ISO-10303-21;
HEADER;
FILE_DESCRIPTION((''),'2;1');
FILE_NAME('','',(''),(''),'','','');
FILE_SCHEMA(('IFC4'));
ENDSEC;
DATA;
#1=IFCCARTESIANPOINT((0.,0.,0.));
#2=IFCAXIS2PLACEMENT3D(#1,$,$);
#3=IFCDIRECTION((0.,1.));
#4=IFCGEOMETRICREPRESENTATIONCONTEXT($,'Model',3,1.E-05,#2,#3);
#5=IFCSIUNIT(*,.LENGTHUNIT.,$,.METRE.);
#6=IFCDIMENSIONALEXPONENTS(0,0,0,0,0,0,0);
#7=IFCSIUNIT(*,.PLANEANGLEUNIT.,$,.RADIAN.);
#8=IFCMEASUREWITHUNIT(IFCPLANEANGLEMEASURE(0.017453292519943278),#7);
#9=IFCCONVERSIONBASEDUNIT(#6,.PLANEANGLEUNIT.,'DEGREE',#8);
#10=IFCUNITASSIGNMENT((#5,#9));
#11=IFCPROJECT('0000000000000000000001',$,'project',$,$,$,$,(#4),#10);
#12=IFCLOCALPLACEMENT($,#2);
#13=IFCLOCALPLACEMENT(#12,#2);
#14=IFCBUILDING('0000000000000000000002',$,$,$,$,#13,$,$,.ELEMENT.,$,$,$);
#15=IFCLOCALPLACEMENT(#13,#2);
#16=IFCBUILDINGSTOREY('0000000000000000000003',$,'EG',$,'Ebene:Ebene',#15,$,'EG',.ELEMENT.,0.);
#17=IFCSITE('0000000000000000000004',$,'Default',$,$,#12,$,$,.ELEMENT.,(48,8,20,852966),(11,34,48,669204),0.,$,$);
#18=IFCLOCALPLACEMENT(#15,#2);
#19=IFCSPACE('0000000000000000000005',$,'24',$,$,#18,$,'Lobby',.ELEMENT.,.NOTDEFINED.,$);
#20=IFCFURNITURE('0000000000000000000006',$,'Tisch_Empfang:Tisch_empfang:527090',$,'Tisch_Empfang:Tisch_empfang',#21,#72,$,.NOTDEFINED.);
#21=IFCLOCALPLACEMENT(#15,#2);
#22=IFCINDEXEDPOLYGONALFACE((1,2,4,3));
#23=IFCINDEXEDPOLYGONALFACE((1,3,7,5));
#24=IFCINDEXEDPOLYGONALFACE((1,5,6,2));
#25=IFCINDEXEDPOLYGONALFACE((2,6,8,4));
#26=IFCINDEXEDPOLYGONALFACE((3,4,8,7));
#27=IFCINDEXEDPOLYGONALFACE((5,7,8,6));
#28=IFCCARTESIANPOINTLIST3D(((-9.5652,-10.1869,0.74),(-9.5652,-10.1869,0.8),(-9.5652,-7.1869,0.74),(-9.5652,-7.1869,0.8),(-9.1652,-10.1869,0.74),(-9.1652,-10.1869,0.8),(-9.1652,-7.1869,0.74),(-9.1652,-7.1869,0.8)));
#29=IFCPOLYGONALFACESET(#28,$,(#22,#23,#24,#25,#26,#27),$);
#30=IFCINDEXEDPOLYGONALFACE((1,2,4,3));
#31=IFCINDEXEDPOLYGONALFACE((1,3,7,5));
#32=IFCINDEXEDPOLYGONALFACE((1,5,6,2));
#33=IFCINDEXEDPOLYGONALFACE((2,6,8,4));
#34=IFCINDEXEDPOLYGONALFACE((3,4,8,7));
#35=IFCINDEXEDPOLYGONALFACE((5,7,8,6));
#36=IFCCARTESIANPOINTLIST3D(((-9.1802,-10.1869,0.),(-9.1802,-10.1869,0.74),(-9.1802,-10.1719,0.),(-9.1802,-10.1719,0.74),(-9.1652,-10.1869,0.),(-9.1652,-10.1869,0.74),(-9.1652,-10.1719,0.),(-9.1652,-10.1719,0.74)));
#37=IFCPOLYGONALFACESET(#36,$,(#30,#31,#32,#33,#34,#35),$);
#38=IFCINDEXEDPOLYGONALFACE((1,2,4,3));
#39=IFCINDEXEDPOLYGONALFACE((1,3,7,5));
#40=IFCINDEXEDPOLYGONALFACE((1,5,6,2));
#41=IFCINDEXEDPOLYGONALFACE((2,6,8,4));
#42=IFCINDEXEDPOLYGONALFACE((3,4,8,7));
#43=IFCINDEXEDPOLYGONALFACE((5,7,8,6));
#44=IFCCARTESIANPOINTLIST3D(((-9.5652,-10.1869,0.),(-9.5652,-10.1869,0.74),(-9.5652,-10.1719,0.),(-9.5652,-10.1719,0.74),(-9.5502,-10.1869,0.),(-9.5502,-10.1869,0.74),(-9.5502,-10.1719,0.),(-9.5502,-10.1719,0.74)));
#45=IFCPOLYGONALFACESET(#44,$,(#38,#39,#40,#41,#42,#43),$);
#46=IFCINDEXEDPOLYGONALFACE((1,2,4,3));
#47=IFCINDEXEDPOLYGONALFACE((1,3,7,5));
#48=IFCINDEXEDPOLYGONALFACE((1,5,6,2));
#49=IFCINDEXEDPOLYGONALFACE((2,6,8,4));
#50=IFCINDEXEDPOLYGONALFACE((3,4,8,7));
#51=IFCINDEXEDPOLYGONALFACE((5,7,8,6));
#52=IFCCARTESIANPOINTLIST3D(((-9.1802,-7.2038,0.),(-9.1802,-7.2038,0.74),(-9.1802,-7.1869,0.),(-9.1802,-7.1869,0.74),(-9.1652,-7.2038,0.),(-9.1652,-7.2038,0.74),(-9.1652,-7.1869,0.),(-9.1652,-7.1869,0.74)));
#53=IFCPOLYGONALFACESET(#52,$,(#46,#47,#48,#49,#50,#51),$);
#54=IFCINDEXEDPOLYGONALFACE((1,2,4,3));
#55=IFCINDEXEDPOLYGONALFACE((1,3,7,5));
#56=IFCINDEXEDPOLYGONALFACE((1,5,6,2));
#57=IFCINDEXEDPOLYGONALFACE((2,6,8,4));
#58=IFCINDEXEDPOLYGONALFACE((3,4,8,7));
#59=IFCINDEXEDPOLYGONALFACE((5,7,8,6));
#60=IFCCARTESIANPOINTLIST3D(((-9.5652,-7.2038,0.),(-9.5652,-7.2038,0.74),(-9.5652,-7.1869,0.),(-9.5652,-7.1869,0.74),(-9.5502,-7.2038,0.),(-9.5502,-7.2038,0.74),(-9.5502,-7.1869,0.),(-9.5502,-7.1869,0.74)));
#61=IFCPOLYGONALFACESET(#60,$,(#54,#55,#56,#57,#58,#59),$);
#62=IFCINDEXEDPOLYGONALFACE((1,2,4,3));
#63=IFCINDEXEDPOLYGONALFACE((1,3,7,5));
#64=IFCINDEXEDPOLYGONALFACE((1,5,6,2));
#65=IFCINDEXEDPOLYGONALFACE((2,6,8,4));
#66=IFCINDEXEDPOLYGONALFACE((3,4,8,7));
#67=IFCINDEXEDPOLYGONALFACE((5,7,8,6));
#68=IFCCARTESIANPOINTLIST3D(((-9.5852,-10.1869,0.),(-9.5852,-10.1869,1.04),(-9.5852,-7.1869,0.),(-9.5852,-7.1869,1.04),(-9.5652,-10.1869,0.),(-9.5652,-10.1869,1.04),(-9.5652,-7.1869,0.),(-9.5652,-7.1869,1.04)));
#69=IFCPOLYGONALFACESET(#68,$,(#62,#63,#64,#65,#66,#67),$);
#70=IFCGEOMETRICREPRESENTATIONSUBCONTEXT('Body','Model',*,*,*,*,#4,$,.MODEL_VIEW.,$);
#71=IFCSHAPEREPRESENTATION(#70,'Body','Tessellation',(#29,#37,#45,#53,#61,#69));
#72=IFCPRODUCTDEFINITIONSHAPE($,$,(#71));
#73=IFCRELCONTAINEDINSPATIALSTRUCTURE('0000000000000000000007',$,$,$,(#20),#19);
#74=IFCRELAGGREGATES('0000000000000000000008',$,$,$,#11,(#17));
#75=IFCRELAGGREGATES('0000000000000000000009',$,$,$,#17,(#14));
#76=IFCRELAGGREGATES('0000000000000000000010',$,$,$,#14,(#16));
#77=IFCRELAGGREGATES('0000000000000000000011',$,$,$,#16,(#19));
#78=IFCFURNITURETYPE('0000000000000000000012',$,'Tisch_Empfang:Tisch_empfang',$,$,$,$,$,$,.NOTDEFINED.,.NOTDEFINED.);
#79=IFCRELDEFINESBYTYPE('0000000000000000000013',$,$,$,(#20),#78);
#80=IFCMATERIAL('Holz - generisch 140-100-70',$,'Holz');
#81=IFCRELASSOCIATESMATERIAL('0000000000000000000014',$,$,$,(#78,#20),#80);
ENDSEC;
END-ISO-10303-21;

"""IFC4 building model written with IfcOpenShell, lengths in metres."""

from ifc_helpers import new_model, entity, si_unit, converted_unit, direction, frame, origin, place, context, subcontext, project, spatial, indexed_curve, outline, extrude, source, transform, mapped, material, type_object, type_shapes, element, save


model = new_model("IFC4")

# Units and contexts
model_context = context("Model", 3, precision=1e-05, world=origin(), true_north=direction((0.0, 1.0)))
body_context = subcontext(model_context, "Body", "Model", "MODEL_VIEW")
ifc_project = project(units=[si_unit("LENGTHUNIT", "METRE"), converted_unit("PLANEANGLEUNIT", "DEGREE", entity("IfcPlaneAngleMeasure", 0.017453292519943278), si_unit("PLANEANGLEUNIT", "RADIAN"), dimensions=[0, 0, 0, 0, 0, 0, 0])], contexts=[model_context])

# Site, building, storey
site_placement = place(None, origin())
site = spatial("IfcSite", under=ifc_project, at=site_placement, Name="Default", CompositionType="ELEMENT", RefLatitude=(48, 8, 20, 852966), RefLongitude=(11, 34, 48, 669204), RefElevation=0.0)
building_placement = place(site_placement, origin())
building = spatial("IfcBuilding", under=site, at=building_placement, CompositionType="ELEMENT")
storey_placement = place(building_placement, origin())
storey = spatial("IfcBuildingStorey", under=building, at=storey_placement, Name="EG", ObjectType="Ebene:Ebene", LongName="EG", CompositionType="ELEMENT", Elevation=0.0)

# Shared definitions
space_placement = place(storey_placement, origin())
space = spatial("IfcSpace", under=storey, at=space_placement, Name="24", LongName="Lobby", CompositionType="ELEMENT", PredefinedType="NOTDEFINED")

# Furniture
ifc_material_1 = material(Name="Holz - generisch 140-100-70", Category="Holz")
furniture_type = type_object("IfcFurnitureType", Name="Tisch_Empfang:Tisch_empfang", AssemblyPlace="NOTDEFINED", PredefinedType="NOTDEFINED", material=ifc_material_1)
shared_shape_1 = source(origin(), body_context, "Body", "SweptSolid", [
    extrude(outline(indexed_curve([(-0.2, -1.5), (0.2, -1.5), (0.2, 1.5), (-0.2, 1.5), (-0.2, -1.5)], self_intersect=False)), frame((1.5, -0.2, 0.74), z_axis=(0.0, 0.0, 1.0), x_axis=(0.0, 1.0, 0.0)), (0.0, 0.0, 1.0), 0.06),
    extrude(outline(indexed_curve([(-0.0075, -0.0075), (0.0075, -0.0075), (0.0075, 0.0075), (-0.0075, 0.0075), (-0.0075, -0.0075)], self_intersect=False)), frame((0.0075, -0.3925, 0.0), z_axis=(0.0, 0.0, 1.0), x_axis=(0.0, 1.0, 0.0)), (0.0, 0.0, 1.0), 0.74),
    extrude(outline(indexed_curve([(-0.0075, -0.0075), (0.0075, -0.0075), (0.0075, 0.0075), (-0.0075, 0.0075), (-0.0075, -0.0075)], self_intersect=False)), frame((0.0075, -0.0075, 0.0), z_axis=(0.0, 0.0, 1.0), x_axis=(0.0, 1.0, 0.0)), (0.0, 0.0, 1.0), 0.74),
    extrude(outline(indexed_curve([(-0.0085, -0.0075), (0.0085, -0.0075), (0.0085, 0.0075), (-0.0085, 0.0075), (-0.0085, -0.0075)], self_intersect=False)), frame((2.9915, -0.3925, 0.0)), (0.0, 0.0, 1.0), 0.74),
    extrude(outline(indexed_curve([(-0.0085, -0.0075), (0.0085, -0.0075), (0.0085, 0.0075), (-0.0085, 0.0075), (-0.0085, -0.0075)], self_intersect=False)), frame((2.9915, -0.0075, 0.0)), (0.0, 0.0, 1.0), 0.74),
    extrude(outline(indexed_curve([(-0.01, -1.5), (0.01, -1.5), (0.01, 1.5), (-0.01, 1.5), (-0.01, -1.5)], self_intersect=False)), frame((1.5, 0.01, 0.0), z_axis=(0.0, 0.0, 1.0), x_axis=(0.0, 1.0, 0.0)), (0.0, 0.0, 1.0), 1.04),
])
type_shapes(furniture_type, [shared_shape_1])
furniture_placement = place(space_placement, frame((-9.5652, -10.1869, 0.0), z_axis=(0.0, 0.0, 1.0), x_axis=(0.0, 1.0, 0.0)))
element("IfcFurniture", 1, at=furniture_placement, inside=space, type_object=furniture_type, material=ifc_material_1, Name="Tisch_Empfang:Tisch_empfang:527090", ObjectType="Tisch_Empfang:Tisch_empfang", PredefinedType="NOTDEFINED", context=body_context, shape_type="MappedRepresentation", body=[
    mapped(shared_shape_1, transform((0.0, 0.0, 0.0), scale=1.0)),
])

save(model, "model.ifc")
